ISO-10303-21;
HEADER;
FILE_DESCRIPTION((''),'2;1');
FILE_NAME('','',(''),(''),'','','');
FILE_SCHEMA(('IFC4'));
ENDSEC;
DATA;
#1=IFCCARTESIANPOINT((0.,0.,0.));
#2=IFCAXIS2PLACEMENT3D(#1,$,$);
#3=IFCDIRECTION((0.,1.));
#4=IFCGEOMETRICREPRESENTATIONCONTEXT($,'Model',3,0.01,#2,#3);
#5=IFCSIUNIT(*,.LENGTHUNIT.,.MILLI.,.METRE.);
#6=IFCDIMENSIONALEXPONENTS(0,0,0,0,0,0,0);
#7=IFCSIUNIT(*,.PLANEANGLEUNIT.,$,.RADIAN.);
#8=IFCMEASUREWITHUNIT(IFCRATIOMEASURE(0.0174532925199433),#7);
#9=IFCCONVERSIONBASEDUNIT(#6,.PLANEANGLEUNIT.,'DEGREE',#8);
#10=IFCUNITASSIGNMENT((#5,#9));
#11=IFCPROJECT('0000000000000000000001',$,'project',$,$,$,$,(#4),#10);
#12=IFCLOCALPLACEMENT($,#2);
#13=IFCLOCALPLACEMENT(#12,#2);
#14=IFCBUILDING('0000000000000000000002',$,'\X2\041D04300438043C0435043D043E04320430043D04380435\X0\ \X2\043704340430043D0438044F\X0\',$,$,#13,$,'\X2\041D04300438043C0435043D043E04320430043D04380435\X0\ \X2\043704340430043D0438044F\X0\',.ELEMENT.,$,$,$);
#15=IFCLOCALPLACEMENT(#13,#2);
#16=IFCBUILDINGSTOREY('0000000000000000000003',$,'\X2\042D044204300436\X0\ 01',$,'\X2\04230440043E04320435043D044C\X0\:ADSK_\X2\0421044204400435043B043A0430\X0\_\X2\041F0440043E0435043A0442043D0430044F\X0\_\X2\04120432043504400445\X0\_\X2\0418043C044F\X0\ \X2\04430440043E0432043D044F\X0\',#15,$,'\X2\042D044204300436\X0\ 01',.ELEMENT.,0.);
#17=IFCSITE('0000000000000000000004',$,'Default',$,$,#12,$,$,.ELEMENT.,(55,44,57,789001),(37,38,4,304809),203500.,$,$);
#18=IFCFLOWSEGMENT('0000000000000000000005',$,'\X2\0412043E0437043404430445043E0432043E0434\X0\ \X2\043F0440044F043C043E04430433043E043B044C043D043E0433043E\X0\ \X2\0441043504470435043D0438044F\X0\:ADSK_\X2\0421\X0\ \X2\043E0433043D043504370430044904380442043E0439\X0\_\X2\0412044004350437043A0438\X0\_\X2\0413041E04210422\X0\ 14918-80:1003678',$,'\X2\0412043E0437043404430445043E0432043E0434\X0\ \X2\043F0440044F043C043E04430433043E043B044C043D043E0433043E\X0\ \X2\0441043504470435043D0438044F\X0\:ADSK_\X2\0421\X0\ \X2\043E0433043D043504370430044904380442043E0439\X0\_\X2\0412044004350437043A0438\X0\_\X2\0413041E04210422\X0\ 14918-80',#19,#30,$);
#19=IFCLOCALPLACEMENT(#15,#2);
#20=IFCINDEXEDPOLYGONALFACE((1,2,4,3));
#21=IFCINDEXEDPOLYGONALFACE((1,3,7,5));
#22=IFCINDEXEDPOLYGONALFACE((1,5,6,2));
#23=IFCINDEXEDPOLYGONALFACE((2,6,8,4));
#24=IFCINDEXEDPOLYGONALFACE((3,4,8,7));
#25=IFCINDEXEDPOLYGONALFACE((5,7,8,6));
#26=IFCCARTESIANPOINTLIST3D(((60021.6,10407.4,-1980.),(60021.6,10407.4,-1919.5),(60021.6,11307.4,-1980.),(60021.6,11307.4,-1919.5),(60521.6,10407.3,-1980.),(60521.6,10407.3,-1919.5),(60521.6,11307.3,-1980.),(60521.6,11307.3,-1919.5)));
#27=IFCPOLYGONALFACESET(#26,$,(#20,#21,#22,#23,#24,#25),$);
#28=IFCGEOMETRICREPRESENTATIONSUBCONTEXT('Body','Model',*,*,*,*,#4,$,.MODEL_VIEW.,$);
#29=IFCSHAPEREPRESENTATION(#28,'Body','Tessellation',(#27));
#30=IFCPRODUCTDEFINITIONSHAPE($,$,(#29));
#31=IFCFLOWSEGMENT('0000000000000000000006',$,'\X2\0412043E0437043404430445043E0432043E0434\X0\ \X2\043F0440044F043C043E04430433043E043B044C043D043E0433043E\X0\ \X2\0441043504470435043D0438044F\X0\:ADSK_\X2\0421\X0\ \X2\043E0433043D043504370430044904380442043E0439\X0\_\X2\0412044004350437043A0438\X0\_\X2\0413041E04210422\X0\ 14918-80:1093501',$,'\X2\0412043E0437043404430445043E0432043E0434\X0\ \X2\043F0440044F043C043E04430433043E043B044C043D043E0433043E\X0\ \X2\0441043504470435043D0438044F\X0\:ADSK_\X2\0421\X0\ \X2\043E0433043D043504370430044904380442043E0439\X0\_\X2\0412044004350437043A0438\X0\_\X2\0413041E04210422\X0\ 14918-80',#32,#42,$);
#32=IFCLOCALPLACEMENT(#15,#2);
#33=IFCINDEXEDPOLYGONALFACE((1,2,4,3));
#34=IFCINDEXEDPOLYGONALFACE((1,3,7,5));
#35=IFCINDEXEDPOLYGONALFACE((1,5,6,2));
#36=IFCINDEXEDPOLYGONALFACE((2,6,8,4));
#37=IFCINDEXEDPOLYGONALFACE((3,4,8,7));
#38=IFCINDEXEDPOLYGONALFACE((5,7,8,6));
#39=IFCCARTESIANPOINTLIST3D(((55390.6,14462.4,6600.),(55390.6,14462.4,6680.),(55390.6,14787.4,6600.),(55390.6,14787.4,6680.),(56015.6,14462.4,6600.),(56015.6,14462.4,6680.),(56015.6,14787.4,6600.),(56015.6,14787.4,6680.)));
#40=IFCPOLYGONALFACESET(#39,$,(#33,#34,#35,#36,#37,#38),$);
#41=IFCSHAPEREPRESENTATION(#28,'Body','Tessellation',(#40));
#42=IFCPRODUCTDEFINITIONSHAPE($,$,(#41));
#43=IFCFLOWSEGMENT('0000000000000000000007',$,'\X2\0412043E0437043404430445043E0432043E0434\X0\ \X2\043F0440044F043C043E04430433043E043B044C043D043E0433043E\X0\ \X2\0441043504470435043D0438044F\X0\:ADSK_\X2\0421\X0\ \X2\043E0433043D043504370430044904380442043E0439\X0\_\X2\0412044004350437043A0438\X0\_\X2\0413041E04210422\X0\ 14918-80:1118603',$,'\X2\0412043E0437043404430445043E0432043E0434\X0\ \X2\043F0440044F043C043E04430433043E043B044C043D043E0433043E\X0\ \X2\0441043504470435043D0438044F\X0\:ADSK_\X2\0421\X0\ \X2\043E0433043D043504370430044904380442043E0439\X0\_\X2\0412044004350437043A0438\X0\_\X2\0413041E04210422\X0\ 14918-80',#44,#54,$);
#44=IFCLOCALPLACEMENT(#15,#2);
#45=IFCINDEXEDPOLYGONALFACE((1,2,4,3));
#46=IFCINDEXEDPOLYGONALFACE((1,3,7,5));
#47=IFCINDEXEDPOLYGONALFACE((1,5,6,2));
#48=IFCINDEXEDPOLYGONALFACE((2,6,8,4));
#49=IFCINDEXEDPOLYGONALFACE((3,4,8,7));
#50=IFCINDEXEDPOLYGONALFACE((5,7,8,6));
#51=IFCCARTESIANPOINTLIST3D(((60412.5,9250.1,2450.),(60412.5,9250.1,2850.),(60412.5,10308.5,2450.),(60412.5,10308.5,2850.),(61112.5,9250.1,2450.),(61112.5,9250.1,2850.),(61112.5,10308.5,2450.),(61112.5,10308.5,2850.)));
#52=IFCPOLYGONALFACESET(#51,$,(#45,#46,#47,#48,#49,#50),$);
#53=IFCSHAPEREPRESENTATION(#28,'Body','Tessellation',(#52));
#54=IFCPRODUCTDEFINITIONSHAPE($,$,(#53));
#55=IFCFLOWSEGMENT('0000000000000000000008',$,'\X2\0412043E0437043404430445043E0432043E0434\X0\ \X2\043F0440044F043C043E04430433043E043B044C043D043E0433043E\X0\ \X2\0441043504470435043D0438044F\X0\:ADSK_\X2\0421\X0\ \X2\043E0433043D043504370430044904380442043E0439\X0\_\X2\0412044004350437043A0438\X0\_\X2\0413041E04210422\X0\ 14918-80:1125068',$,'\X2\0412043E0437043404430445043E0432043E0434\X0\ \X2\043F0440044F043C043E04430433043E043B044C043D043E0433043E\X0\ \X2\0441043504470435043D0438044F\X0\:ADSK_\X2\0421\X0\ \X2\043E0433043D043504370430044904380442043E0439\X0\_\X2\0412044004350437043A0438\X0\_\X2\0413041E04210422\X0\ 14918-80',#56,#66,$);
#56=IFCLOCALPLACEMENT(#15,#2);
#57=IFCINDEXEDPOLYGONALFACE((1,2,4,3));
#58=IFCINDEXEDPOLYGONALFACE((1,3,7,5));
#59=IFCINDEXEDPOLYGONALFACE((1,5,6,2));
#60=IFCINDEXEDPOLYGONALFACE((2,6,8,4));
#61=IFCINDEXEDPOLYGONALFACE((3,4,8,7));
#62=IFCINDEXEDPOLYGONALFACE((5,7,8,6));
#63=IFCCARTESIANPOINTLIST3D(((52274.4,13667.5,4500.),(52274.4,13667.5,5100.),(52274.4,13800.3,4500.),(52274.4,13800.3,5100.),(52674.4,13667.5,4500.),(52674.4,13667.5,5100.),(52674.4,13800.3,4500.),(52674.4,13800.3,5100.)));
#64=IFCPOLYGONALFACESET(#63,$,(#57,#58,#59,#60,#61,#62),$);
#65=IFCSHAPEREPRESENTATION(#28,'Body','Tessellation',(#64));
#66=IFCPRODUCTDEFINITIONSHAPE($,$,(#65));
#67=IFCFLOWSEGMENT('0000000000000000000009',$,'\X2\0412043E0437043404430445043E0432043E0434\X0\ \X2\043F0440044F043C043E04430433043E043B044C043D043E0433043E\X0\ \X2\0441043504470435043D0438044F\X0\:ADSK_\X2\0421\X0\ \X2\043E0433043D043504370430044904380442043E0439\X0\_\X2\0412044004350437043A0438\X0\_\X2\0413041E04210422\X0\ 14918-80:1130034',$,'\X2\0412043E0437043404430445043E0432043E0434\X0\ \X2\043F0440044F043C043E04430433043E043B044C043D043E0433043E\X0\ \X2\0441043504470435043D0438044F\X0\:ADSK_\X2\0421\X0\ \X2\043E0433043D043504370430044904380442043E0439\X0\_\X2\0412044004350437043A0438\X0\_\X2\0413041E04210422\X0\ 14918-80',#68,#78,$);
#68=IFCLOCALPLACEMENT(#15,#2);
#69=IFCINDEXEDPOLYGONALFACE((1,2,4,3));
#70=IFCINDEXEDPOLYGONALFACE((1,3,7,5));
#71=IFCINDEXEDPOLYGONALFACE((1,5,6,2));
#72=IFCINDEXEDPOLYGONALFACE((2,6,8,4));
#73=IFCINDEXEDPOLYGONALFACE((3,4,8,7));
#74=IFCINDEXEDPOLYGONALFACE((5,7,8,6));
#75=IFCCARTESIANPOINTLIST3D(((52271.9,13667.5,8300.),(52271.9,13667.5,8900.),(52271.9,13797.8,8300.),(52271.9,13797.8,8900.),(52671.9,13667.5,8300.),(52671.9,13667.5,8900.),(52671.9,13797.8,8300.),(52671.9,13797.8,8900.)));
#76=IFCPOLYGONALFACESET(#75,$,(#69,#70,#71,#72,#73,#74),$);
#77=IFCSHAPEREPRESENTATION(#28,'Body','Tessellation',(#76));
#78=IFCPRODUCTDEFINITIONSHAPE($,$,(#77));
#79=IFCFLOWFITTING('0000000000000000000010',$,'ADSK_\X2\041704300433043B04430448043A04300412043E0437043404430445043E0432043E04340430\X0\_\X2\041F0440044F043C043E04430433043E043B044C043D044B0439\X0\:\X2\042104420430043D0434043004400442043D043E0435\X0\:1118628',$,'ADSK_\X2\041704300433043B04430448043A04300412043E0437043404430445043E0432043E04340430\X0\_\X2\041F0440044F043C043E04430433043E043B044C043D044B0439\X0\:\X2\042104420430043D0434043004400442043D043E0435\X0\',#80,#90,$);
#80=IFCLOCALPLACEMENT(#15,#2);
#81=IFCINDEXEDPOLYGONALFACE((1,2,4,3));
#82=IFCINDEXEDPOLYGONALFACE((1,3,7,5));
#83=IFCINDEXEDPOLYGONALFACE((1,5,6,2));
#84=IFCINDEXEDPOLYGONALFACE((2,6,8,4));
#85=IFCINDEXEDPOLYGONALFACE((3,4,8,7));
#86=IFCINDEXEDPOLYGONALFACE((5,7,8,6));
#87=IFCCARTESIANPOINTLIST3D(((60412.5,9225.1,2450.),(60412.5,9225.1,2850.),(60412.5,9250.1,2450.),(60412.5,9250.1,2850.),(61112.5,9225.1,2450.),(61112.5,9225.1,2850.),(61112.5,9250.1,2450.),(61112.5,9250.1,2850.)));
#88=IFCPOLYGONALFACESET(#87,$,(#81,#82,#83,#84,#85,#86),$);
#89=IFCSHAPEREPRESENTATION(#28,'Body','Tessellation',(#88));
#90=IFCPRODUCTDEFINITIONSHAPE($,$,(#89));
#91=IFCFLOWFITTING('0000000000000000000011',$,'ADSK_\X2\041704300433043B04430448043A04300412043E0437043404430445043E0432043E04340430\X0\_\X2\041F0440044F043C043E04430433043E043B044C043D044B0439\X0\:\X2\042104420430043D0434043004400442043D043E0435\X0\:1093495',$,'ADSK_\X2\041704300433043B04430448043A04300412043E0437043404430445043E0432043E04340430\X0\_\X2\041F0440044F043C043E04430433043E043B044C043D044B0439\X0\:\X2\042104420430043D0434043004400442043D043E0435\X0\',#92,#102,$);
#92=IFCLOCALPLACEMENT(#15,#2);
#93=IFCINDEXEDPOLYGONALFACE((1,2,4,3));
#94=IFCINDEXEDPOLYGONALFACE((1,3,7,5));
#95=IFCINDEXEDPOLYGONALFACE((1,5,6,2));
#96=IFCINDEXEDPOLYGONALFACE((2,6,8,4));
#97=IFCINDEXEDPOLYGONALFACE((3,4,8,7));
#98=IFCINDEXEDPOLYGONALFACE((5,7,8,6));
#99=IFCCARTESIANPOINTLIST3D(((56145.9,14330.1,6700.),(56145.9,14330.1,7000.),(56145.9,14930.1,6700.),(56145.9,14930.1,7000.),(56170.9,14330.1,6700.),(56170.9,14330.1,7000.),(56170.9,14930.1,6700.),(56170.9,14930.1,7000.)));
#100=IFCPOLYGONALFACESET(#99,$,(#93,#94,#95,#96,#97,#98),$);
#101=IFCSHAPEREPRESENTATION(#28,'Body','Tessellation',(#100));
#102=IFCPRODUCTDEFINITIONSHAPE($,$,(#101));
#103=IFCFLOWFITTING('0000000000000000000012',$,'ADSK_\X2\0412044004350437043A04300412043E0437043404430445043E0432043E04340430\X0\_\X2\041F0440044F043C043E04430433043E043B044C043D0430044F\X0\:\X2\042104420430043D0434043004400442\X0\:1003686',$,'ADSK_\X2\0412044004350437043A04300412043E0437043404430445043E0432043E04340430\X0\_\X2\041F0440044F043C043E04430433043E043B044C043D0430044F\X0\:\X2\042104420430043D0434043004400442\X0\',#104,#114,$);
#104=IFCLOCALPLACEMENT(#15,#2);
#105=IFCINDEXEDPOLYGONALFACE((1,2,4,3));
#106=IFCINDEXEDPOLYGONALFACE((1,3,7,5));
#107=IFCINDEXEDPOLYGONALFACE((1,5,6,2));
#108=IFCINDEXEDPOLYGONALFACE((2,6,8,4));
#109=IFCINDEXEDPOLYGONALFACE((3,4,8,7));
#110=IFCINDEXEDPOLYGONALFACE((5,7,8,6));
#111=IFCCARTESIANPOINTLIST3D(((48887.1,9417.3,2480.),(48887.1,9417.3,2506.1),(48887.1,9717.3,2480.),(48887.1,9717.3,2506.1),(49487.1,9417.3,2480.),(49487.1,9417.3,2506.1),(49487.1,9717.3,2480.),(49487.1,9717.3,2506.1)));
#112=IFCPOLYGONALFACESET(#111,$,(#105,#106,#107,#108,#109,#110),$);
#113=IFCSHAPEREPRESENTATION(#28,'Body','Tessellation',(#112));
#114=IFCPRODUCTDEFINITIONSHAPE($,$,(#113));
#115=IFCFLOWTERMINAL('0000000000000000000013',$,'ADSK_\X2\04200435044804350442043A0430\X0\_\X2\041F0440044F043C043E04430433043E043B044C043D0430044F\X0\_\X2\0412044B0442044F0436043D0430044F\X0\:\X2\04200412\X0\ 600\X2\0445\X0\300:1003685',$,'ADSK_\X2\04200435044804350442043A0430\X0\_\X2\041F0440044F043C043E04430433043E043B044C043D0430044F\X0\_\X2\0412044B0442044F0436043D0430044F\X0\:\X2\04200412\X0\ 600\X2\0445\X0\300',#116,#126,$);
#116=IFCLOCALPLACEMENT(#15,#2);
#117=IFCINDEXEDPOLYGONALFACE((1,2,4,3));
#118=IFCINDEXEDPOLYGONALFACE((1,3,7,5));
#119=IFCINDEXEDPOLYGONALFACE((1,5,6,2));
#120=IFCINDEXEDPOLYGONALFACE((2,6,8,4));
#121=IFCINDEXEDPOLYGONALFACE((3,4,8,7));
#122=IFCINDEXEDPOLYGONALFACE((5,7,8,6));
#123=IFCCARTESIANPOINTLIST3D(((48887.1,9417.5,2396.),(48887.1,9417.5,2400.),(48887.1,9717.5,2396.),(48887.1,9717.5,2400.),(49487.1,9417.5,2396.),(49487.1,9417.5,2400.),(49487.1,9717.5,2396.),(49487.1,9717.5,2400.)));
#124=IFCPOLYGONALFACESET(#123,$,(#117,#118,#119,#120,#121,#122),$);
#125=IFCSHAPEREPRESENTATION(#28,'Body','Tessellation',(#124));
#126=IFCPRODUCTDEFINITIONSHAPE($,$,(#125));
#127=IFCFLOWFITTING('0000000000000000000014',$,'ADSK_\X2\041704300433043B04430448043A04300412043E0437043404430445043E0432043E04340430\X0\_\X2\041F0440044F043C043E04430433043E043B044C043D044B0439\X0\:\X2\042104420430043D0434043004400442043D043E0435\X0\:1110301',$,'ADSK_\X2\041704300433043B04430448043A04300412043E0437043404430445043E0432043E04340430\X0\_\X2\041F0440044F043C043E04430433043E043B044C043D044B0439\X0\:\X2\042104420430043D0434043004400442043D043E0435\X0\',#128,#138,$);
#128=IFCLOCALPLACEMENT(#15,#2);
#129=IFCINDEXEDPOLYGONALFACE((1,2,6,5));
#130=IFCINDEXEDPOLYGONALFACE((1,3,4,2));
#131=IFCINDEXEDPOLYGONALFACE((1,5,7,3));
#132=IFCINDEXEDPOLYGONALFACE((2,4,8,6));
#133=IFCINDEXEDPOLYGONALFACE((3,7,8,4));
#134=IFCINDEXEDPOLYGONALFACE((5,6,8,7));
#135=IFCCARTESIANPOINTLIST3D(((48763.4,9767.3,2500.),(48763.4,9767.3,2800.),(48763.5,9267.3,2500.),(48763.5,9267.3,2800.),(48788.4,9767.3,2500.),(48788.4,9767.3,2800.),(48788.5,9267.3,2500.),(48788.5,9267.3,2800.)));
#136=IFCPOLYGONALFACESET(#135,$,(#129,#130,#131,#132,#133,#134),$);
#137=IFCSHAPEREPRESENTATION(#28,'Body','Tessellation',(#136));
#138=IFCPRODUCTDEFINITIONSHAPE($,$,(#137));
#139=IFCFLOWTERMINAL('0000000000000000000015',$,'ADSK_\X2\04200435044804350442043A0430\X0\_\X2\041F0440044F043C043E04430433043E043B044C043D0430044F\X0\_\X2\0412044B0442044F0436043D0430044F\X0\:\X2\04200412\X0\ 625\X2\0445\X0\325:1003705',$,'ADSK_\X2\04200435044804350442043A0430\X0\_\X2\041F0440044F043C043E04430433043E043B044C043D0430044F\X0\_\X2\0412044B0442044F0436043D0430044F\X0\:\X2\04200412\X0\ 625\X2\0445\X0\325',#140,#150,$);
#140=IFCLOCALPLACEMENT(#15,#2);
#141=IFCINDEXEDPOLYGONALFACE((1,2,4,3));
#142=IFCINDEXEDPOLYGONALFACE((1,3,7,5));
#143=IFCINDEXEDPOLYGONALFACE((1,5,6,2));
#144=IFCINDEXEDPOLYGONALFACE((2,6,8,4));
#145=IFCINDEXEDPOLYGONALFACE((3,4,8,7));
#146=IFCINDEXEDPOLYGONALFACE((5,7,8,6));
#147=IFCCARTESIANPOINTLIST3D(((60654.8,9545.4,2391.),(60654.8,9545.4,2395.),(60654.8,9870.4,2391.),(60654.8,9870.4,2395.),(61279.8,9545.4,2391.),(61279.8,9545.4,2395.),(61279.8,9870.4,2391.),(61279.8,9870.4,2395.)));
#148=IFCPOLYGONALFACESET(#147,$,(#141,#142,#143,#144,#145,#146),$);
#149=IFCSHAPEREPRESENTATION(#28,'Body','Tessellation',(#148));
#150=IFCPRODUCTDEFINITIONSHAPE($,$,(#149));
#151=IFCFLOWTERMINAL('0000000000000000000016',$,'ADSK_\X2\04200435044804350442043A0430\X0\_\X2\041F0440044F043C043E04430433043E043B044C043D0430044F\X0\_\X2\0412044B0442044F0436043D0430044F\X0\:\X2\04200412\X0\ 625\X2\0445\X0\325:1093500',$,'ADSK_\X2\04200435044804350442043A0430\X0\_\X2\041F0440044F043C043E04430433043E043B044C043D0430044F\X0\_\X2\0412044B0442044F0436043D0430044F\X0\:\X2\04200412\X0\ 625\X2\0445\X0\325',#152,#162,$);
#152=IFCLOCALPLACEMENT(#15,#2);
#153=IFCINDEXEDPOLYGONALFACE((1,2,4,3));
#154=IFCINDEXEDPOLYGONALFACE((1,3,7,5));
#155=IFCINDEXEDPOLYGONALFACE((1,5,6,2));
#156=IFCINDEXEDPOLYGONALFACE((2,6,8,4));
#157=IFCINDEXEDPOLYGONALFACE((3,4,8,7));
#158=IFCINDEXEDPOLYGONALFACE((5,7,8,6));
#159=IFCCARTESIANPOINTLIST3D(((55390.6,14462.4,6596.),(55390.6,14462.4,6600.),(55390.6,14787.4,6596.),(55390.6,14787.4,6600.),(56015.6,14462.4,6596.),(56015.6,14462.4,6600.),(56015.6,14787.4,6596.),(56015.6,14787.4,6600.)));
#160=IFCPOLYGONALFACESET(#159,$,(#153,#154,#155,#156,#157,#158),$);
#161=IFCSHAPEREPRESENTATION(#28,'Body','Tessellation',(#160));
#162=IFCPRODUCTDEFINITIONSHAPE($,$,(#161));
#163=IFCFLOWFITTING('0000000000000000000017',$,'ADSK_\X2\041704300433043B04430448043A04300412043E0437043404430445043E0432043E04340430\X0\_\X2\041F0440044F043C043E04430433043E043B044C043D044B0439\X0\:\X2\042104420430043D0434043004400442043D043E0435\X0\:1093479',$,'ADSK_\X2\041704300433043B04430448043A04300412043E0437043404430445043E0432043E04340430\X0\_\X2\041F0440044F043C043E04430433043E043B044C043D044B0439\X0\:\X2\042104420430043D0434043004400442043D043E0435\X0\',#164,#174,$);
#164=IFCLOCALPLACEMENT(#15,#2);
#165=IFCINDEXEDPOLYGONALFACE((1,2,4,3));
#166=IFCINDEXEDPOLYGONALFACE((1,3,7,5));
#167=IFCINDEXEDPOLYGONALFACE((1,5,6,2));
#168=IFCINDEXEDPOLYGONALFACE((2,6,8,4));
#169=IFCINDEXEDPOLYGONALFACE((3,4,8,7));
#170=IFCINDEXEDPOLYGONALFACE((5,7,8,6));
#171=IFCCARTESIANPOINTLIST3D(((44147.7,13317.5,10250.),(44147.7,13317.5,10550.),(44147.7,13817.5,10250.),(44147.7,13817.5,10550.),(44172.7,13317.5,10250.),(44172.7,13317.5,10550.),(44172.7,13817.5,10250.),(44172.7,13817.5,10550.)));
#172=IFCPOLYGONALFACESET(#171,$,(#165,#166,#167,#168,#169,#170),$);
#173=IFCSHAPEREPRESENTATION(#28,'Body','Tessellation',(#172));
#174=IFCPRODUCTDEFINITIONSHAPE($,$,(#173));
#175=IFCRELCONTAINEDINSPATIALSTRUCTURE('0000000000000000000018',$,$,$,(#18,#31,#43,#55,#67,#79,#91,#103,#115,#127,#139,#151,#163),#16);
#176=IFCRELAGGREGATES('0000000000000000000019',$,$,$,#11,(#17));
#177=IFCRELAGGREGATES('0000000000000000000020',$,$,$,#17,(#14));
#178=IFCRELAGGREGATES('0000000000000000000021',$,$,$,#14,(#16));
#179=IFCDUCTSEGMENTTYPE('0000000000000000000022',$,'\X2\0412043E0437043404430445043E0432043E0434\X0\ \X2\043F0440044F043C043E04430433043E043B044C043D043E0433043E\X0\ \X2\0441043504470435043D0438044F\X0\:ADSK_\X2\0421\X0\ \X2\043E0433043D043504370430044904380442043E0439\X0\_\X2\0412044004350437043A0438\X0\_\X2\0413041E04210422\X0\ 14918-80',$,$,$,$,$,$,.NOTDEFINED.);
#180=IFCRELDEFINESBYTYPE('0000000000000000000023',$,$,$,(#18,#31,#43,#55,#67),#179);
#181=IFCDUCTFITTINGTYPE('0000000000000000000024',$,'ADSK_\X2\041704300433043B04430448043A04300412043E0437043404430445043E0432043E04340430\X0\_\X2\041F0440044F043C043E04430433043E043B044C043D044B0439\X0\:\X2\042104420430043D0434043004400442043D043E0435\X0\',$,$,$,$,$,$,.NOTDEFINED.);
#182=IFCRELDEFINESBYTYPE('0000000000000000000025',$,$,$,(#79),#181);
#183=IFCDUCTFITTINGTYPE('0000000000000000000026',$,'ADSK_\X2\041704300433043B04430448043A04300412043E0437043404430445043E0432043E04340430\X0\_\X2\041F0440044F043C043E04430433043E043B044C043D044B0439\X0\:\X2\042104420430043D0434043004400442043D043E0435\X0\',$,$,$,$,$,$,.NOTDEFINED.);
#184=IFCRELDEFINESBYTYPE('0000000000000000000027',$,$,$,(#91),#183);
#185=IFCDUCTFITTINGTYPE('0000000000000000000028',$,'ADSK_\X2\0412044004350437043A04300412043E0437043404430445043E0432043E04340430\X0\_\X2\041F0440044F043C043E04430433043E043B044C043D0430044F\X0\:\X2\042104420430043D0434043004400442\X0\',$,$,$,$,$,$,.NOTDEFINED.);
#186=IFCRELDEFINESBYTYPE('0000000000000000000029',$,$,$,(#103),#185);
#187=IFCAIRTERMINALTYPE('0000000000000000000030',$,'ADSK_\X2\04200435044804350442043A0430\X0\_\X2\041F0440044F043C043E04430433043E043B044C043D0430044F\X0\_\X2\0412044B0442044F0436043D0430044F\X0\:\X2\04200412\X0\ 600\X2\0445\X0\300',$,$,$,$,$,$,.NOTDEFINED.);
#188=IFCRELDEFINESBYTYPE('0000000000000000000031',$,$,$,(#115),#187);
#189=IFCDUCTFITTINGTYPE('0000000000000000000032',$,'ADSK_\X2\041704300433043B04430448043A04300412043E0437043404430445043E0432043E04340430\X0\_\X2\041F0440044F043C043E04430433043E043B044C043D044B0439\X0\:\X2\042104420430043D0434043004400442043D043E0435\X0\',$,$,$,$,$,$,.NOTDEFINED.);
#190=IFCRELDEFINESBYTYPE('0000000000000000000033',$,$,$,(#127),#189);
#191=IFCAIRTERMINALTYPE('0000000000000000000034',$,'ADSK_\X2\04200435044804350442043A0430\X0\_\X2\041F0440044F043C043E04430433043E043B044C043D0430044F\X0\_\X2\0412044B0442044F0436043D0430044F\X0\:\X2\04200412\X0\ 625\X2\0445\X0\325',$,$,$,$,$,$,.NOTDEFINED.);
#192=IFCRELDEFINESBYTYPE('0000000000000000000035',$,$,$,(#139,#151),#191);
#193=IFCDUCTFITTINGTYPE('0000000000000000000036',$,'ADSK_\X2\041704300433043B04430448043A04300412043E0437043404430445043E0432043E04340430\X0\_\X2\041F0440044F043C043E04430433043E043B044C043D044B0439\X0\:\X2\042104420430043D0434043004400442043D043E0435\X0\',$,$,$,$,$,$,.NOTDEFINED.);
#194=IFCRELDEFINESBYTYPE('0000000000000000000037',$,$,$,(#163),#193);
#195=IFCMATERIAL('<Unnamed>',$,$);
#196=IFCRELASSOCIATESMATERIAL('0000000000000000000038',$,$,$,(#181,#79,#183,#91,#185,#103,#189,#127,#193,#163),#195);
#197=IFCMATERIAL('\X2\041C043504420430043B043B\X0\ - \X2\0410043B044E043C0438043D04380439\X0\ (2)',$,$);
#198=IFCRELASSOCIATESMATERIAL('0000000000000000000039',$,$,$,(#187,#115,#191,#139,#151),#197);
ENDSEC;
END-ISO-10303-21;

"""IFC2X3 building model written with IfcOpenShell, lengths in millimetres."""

from ifc_helpers import new_model, entity, si_unit, converted_unit, direction, frame, origin, origin_2d_with_axis, place, context, subcontext, project, spatial, rectangle, extrude, source, transform, mapped, material, type_object, type_shapes, element, save


model = new_model("IFC2X3")

# Units and contexts
model_context = context("Model", 3, precision=0.01, world=origin(), true_north=direction((0.0, 1.0)))
body_context = subcontext(model_context, "Body", "Model", "MODEL_VIEW")
ifc_project = project(units=[si_unit("LENGTHUNIT", "METRE", prefix="MILLI"), converted_unit("PLANEANGLEUNIT", "DEGREE", entity("IfcRatioMeasure", 0.0174532925199433), si_unit("PLANEANGLEUNIT", "RADIAN"), dimensions=[0, 0, 0, 0, 0, 0, 0])], contexts=[model_context])

# Site, building, storey
site_placement = place(None, origin())
site = spatial("IfcSite", under=ifc_project, at=site_placement, Name="Default", CompositionType="ELEMENT", RefLatitude=(55, 44, 57, 789001), RefLongitude=(37, 38, 4, 304809), RefElevation=203500.0)
building_placement = place(site_placement, origin())
building = spatial("IfcBuilding", under=site, at=building_placement, Name="Наименование здания", LongName="Наименование здания", CompositionType="ELEMENT")
storey_placement = place(building_placement, origin())
storey = spatial("IfcBuildingStorey", under=building, at=storey_placement, Name="Этаж 01", ObjectType="Уровень:ADSK_Стрелка_Проектная_Вверх_Имя уровня", LongName="Этаж 01", CompositionType="ELEMENT", Elevation=0.0)

# Flow segments
duct_segment_type = type_object("IfcDuctSegmentType", Name="Воздуховод прямоугольного сечения:ADSK_С огнезащитой_Врезки_ГОСТ 14918-80", PredefinedType="NOTDEFINED")
flow_segment_1_placement = place(storey_placement, frame((60021.6, 10407.4, -1980.0)))
element("IfcFlowSegment", 1, at=flow_segment_1_placement, inside=storey, type_object=duct_segment_type, Name="Воздуховод прямоугольного сечения:ADSK_С огнезащитой_Врезки_ГОСТ 14918-80:1003678", ObjectType="Воздуховод прямоугольного сечения:ADSK_С огнезащитой_Врезки_ГОСТ 14918-80", context=body_context, shape_type="SweptSolid", body=[
    extrude(rectangle(XDim=900.0, YDim=500.0, at=origin_2d_with_axis()), frame((250.0, 450.0, 0.0), z_axis=(0.0, 0.0, 1.0), x_axis=(-0.000005, -1.0, 0.0)), (0.0, 0.0, 1.0), 60.5),
])
flow_segment_2_placement = place(storey_placement, frame((55390.6, 14462.4, 6600.0)))
element("IfcFlowSegment", 2, at=flow_segment_2_placement, inside=storey, type_object=duct_segment_type, Name="Воздуховод прямоугольного сечения:ADSK_С огнезащитой_Врезки_ГОСТ 14918-80:1093501", ObjectType="Воздуховод прямоугольного сечения:ADSK_С огнезащитой_Врезки_ГОСТ 14918-80", context=body_context, shape_type="SweptSolid", body=[
    extrude(rectangle(XDim=325.0, YDim=625.0, at=origin_2d_with_axis()), frame((312.5, 162.5, 0.0), z_axis=(0.0, 0.0, 1.0), x_axis=(0.0, -1.0, 0.0)), (0.0, 0.0, 1.0), 80.0),
])
flow_segment_3_placement = place(storey_placement, frame((60412.5, 9250.1, 2450.0)))
element("IfcFlowSegment", 3, at=flow_segment_3_placement, inside=storey, type_object=duct_segment_type, Name="Воздуховод прямоугольного сечения:ADSK_С огнезащитой_Врезки_ГОСТ 14918-80:1118603", ObjectType="Воздуховод прямоугольного сечения:ADSK_С огнезащитой_Врезки_ГОСТ 14918-80", context=body_context, shape_type="SweptSolid", body=[
    extrude(rectangle(XDim=1058.4, YDim=700.0, at=origin_2d_with_axis()), frame((350.0, 529.2, 0.0), z_axis=(0.0, 0.0, 1.0), x_axis=(0.0, -1.0, 0.0)), (0.0, 0.0, 1.0), 400.0),
])
flow_segment_4_placement = place(storey_placement, frame((52274.4, 13667.5, 4500.0)))
element("IfcFlowSegment", 4, at=flow_segment_4_placement, inside=storey, type_object=duct_segment_type, Name="Воздуховод прямоугольного сечения:ADSK_С огнезащитой_Врезки_ГОСТ 14918-80:1125068", ObjectType="Воздуховод прямоугольного сечения:ADSK_С огнезащитой_Врезки_ГОСТ 14918-80", context=body_context, shape_type="SweptSolid", body=[
    extrude(rectangle(XDim=132.8, YDim=400.0, at=origin_2d_with_axis()), frame((200.0, 66.4, 0.0), z_axis=(0.0, 0.0, 1.0), x_axis=(0.0, 1.0, 0.0)), (0.0, 0.0, 1.0), 600.0),
])
flow_segment_5_placement = place(storey_placement, frame((52271.9, 13667.5, 8300.0)))
element("IfcFlowSegment", 5, at=flow_segment_5_placement, inside=storey, type_object=duct_segment_type, Name="Воздуховод прямоугольного сечения:ADSK_С огнезащитой_Врезки_ГОСТ 14918-80:1130034", ObjectType="Воздуховод прямоугольного сечения:ADSK_С огнезащитой_Врезки_ГОСТ 14918-80", context=body_context, shape_type="SweptSolid", body=[
    extrude(rectangle(XDim=130.3, YDim=400.0, at=origin_2d_with_axis()), frame((200.0, 65.1, 0.0), z_axis=(0.0, 0.0, 1.0), x_axis=(0.0, 1.0, 0.0)), (0.0, 0.0, 1.0), 600.0),
])

# Flow fittings
ifc_material_1 = material(Name="<Unnamed>")
duct_fitting_type_1 = type_object("IfcDuctFittingType", Name="ADSK_ЗаглушкаВоздуховода_Прямоугольный:Стандартное", PredefinedType="NOTDEFINED", material=ifc_material_1)
shared_shape_1 = source(origin(), body_context, "Body", "SweptSolid", [
    extrude(rectangle(XDim=25.0, YDim=700.0, at=origin_2d_with_axis()), frame((12.5, 0.0, -200.0)), (0.0, 0.0, 1.0), 400.0),
])
type_shapes(duct_fitting_type_1, [shared_shape_1])
flow_fitting_1_placement = place(storey_placement, frame((60762.5, 9250.1, 2650.0), z_axis=(0.0, 0.0, 1.0), x_axis=(0.0, -1.0, 0.0)))
element("IfcFlowFitting", 6, at=flow_fitting_1_placement, inside=storey, type_object=duct_fitting_type_1, material=ifc_material_1, Name="ADSK_ЗаглушкаВоздуховода_Прямоугольный:Стандартное:1118628", ObjectType="ADSK_ЗаглушкаВоздуховода_Прямоугольный:Стандартное", context=body_context, shape_type="MappedRepresentation", body=[
    mapped(shared_shape_1, transform((0.0, 0.0, 0.0), scale=1.0)),
])
duct_fitting_type_2 = type_object("IfcDuctFittingType", Name="ADSK_ЗаглушкаВоздуховода_Прямоугольный:Стандартное", PredefinedType="NOTDEFINED", material=ifc_material_1)
shared_shape_2 = source(origin(), body_context, "Body", "SweptSolid", [
    extrude(rectangle(XDim=25.0, YDim=600.0, at=origin_2d_with_axis()), frame((12.5, 0.0, -150.0)), (0.0, 0.0, 1.0), 300.0),
])
type_shapes(duct_fitting_type_2, [shared_shape_2])
flow_fitting_2_placement = place(storey_placement, frame((56145.9, 14630.1, 6850.0)))
element("IfcFlowFitting", 7, at=flow_fitting_2_placement, inside=storey, type_object=duct_fitting_type_2, material=ifc_material_1, Name="ADSK_ЗаглушкаВоздуховода_Прямоугольный:Стандартное:1093495", ObjectType="ADSK_ЗаглушкаВоздуховода_Прямоугольный:Стандартное", context=body_context, shape_type="MappedRepresentation", body=[
    mapped(shared_shape_2, transform((0.0, 0.0, 0.0), scale=1.0)),
])
duct_fitting_type_3 = type_object("IfcDuctFittingType", Name="ADSK_ВрезкаВоздуховода_Прямоугольная:Стандарт", PredefinedType="NOTDEFINED", material=ifc_material_1)
shared_shape_3 = source(origin(), body_context, "Body", "SweptSolid", [
    extrude(rectangle(XDim=600.0, YDim=26.1, at=origin_2d_with_axis()), frame((7.0, 0.0, -150.0), z_axis=(0.0, 0.0, 1.0), x_axis=(0.0, -1.0, 0.0)), (0.0, 0.0, 1.0), 300.0),
])
type_shapes(duct_fitting_type_3, [shared_shape_3])
flow_fitting_3_placement = place(storey_placement, frame((49187.1, 9567.3, 2500.0), z_axis=(0.000005, 1.0, 0.0), x_axis=(0.0, 0.0, -1.0)))
element("IfcFlowFitting", 8, at=flow_fitting_3_placement, inside=storey, type_object=duct_fitting_type_3, material=ifc_material_1, Name="ADSK_ВрезкаВоздуховода_Прямоугольная:Стандарт:1003686", ObjectType="ADSK_ВрезкаВоздуховода_Прямоугольная:Стандарт", context=body_context, shape_type="MappedRepresentation", body=[
    mapped(shared_shape_3, transform((0.0, 0.0, 0.0), scale=1.0)),
])

# Flow terminal
ifc_material_2 = material(Name="Металл - Алюминий (2)")
air_terminal_type_1 = type_object("IfcAirTerminalType", Name="ADSK_Решетка_Прямоугольная_Вытяжная:РВ 600х300", PredefinedType="NOTDEFINED", material=ifc_material_2)
shared_shape_4 = source(origin(), body_context, "Body", "SweptSolid", [
    extrude(rectangle(XDim=4.0, YDim=600.0, at=origin_2d_with_axis()), frame((0.0, -2.0, -150.0), z_axis=(0.0, 0.0, 1.0), x_axis=(0.0, 1.0, 0.0)), (0.0, 0.0, 1.0), 300.0),
])
type_shapes(air_terminal_type_1, [shared_shape_4])
flow_terminal_placement = place(storey_placement, frame((49187.1, 9567.5, 2400.0), z_axis=(0.0, -1.0, 0.0), x_axis=(1.0, 0.0, 0.0)))
element("IfcFlowTerminal", 9, at=flow_terminal_placement, inside=storey, type_object=air_terminal_type_1, material=ifc_material_2, Name="ADSK_Решетка_Прямоугольная_Вытяжная:РВ 600х300:1003685", ObjectType="ADSK_Решетка_Прямоугольная_Вытяжная:РВ 600х300", context=body_context, shape_type="MappedRepresentation", body=[
    mapped(shared_shape_4, transform((0.0, 0.0, 0.0), scale=1.0)),
])

# Flow fitting
duct_fitting_type_4 = type_object("IfcDuctFittingType", Name="ADSK_ЗаглушкаВоздуховода_Прямоугольный:Стандартное", PredefinedType="NOTDEFINED", material=ifc_material_1)
shared_shape_5 = source(origin(), body_context, "Body", "SweptSolid", [
    extrude(rectangle(XDim=25.0, YDim=500.0, at=origin_2d_with_axis()), frame((12.5, 0.0, -150.0)), (0.0, 0.0, 1.0), 300.0),
])
type_shapes(duct_fitting_type_4, [shared_shape_5])
flow_fitting_4_placement = place(storey_placement, frame((48788.4, 9517.3, 2650.0), z_axis=(0.0, 0.0, 1.0), x_axis=(-1.0, 0.0, 0.0)))
element("IfcFlowFitting", 10, at=flow_fitting_4_placement, inside=storey, type_object=duct_fitting_type_4, material=ifc_material_1, Name="ADSK_ЗаглушкаВоздуховода_Прямоугольный:Стандартное:1110301", ObjectType="ADSK_ЗаглушкаВоздуховода_Прямоугольный:Стандартное", context=body_context, shape_type="MappedRepresentation", body=[
    mapped(shared_shape_5, transform((0.0, 0.0, 0.0), scale=1.0)),
])

# Flow terminals
air_terminal_type_2 = type_object("IfcAirTerminalType", Name="ADSK_Решетка_Прямоугольная_Вытяжная:РВ 625х325", PredefinedType="NOTDEFINED", material=ifc_material_2)
shared_shape_6 = source(origin(), body_context, "Body", "SweptSolid", [
    extrude(rectangle(XDim=4.0, YDim=625.0, at=origin_2d_with_axis()), frame((0.0, -2.0, -162.5), z_axis=(0.0, 0.0, 1.0), x_axis=(0.0, 1.0, 0.0)), (0.0, 0.0, 1.0), 325.0),
])
type_shapes(air_terminal_type_2, [shared_shape_6])
for number, where, z_axis, x_axis, name in (
    (11, (60967.3, 9708.0, 2395.0), (0.0, -1.0, 0.0), (1.0, 0.0, 0.0), "ADSK_Решетка_Прямоугольная_Вытяжная:РВ 625х325:1003705"),
    (12, (55703.1, 14624.9, 6600.0), (0.0, 1.0, 0.0), (-1.0, 0.0, 0.0), "ADSK_Решетка_Прямоугольная_Вытяжная:РВ 625х325:1093500"),
):
    element("IfcFlowTerminal", number, at=place(storey_placement, frame(where, z_axis=z_axis, x_axis=x_axis)), inside=storey, type_object=air_terminal_type_2, material=ifc_material_2, Name=name, ObjectType="ADSK_Решетка_Прямоугольная_Вытяжная:РВ 625х325", context=body_context, shape_type="MappedRepresentation", body=[
        mapped(shared_shape_6, transform((0.0, 0.0, 0.0), scale=1.0)),
    ])

# Flow fitting
duct_fitting_type_5 = type_object("IfcDuctFittingType", Name="ADSK_ЗаглушкаВоздуховода_Прямоугольный:Стандартное", PredefinedType="NOTDEFINED", material=ifc_material_1)
shared_shape_7 = source(origin(), body_context, "Body", "SweptSolid", [
    extrude(rectangle(XDim=25.0, YDim=300.0, at=origin_2d_with_axis()), frame((12.5, 0.0, -250.0)), (0.0, 0.0, 1.0), 500.0),
])
type_shapes(duct_fitting_type_5, [shared_shape_7])
flow_fitting_5_placement = place(storey_placement, frame((44147.7, 13567.5, 10400.0), z_axis=(0.0, 1.0, 0.0), x_axis=(1.0, 0.0, 0.0)))
element("IfcFlowFitting", 13, at=flow_fitting_5_placement, inside=storey, type_object=duct_fitting_type_5, material=ifc_material_1, Name="ADSK_ЗаглушкаВоздуховода_Прямоугольный:Стандартное:1093479", ObjectType="ADSK_ЗаглушкаВоздуховода_Прямоугольный:Стандартное", context=body_context, shape_type="MappedRepresentation", body=[
    mapped(shared_shape_7, transform((0.0, 0.0, 0.0), scale=1.0)),
])

save(model, "model.ifc")
